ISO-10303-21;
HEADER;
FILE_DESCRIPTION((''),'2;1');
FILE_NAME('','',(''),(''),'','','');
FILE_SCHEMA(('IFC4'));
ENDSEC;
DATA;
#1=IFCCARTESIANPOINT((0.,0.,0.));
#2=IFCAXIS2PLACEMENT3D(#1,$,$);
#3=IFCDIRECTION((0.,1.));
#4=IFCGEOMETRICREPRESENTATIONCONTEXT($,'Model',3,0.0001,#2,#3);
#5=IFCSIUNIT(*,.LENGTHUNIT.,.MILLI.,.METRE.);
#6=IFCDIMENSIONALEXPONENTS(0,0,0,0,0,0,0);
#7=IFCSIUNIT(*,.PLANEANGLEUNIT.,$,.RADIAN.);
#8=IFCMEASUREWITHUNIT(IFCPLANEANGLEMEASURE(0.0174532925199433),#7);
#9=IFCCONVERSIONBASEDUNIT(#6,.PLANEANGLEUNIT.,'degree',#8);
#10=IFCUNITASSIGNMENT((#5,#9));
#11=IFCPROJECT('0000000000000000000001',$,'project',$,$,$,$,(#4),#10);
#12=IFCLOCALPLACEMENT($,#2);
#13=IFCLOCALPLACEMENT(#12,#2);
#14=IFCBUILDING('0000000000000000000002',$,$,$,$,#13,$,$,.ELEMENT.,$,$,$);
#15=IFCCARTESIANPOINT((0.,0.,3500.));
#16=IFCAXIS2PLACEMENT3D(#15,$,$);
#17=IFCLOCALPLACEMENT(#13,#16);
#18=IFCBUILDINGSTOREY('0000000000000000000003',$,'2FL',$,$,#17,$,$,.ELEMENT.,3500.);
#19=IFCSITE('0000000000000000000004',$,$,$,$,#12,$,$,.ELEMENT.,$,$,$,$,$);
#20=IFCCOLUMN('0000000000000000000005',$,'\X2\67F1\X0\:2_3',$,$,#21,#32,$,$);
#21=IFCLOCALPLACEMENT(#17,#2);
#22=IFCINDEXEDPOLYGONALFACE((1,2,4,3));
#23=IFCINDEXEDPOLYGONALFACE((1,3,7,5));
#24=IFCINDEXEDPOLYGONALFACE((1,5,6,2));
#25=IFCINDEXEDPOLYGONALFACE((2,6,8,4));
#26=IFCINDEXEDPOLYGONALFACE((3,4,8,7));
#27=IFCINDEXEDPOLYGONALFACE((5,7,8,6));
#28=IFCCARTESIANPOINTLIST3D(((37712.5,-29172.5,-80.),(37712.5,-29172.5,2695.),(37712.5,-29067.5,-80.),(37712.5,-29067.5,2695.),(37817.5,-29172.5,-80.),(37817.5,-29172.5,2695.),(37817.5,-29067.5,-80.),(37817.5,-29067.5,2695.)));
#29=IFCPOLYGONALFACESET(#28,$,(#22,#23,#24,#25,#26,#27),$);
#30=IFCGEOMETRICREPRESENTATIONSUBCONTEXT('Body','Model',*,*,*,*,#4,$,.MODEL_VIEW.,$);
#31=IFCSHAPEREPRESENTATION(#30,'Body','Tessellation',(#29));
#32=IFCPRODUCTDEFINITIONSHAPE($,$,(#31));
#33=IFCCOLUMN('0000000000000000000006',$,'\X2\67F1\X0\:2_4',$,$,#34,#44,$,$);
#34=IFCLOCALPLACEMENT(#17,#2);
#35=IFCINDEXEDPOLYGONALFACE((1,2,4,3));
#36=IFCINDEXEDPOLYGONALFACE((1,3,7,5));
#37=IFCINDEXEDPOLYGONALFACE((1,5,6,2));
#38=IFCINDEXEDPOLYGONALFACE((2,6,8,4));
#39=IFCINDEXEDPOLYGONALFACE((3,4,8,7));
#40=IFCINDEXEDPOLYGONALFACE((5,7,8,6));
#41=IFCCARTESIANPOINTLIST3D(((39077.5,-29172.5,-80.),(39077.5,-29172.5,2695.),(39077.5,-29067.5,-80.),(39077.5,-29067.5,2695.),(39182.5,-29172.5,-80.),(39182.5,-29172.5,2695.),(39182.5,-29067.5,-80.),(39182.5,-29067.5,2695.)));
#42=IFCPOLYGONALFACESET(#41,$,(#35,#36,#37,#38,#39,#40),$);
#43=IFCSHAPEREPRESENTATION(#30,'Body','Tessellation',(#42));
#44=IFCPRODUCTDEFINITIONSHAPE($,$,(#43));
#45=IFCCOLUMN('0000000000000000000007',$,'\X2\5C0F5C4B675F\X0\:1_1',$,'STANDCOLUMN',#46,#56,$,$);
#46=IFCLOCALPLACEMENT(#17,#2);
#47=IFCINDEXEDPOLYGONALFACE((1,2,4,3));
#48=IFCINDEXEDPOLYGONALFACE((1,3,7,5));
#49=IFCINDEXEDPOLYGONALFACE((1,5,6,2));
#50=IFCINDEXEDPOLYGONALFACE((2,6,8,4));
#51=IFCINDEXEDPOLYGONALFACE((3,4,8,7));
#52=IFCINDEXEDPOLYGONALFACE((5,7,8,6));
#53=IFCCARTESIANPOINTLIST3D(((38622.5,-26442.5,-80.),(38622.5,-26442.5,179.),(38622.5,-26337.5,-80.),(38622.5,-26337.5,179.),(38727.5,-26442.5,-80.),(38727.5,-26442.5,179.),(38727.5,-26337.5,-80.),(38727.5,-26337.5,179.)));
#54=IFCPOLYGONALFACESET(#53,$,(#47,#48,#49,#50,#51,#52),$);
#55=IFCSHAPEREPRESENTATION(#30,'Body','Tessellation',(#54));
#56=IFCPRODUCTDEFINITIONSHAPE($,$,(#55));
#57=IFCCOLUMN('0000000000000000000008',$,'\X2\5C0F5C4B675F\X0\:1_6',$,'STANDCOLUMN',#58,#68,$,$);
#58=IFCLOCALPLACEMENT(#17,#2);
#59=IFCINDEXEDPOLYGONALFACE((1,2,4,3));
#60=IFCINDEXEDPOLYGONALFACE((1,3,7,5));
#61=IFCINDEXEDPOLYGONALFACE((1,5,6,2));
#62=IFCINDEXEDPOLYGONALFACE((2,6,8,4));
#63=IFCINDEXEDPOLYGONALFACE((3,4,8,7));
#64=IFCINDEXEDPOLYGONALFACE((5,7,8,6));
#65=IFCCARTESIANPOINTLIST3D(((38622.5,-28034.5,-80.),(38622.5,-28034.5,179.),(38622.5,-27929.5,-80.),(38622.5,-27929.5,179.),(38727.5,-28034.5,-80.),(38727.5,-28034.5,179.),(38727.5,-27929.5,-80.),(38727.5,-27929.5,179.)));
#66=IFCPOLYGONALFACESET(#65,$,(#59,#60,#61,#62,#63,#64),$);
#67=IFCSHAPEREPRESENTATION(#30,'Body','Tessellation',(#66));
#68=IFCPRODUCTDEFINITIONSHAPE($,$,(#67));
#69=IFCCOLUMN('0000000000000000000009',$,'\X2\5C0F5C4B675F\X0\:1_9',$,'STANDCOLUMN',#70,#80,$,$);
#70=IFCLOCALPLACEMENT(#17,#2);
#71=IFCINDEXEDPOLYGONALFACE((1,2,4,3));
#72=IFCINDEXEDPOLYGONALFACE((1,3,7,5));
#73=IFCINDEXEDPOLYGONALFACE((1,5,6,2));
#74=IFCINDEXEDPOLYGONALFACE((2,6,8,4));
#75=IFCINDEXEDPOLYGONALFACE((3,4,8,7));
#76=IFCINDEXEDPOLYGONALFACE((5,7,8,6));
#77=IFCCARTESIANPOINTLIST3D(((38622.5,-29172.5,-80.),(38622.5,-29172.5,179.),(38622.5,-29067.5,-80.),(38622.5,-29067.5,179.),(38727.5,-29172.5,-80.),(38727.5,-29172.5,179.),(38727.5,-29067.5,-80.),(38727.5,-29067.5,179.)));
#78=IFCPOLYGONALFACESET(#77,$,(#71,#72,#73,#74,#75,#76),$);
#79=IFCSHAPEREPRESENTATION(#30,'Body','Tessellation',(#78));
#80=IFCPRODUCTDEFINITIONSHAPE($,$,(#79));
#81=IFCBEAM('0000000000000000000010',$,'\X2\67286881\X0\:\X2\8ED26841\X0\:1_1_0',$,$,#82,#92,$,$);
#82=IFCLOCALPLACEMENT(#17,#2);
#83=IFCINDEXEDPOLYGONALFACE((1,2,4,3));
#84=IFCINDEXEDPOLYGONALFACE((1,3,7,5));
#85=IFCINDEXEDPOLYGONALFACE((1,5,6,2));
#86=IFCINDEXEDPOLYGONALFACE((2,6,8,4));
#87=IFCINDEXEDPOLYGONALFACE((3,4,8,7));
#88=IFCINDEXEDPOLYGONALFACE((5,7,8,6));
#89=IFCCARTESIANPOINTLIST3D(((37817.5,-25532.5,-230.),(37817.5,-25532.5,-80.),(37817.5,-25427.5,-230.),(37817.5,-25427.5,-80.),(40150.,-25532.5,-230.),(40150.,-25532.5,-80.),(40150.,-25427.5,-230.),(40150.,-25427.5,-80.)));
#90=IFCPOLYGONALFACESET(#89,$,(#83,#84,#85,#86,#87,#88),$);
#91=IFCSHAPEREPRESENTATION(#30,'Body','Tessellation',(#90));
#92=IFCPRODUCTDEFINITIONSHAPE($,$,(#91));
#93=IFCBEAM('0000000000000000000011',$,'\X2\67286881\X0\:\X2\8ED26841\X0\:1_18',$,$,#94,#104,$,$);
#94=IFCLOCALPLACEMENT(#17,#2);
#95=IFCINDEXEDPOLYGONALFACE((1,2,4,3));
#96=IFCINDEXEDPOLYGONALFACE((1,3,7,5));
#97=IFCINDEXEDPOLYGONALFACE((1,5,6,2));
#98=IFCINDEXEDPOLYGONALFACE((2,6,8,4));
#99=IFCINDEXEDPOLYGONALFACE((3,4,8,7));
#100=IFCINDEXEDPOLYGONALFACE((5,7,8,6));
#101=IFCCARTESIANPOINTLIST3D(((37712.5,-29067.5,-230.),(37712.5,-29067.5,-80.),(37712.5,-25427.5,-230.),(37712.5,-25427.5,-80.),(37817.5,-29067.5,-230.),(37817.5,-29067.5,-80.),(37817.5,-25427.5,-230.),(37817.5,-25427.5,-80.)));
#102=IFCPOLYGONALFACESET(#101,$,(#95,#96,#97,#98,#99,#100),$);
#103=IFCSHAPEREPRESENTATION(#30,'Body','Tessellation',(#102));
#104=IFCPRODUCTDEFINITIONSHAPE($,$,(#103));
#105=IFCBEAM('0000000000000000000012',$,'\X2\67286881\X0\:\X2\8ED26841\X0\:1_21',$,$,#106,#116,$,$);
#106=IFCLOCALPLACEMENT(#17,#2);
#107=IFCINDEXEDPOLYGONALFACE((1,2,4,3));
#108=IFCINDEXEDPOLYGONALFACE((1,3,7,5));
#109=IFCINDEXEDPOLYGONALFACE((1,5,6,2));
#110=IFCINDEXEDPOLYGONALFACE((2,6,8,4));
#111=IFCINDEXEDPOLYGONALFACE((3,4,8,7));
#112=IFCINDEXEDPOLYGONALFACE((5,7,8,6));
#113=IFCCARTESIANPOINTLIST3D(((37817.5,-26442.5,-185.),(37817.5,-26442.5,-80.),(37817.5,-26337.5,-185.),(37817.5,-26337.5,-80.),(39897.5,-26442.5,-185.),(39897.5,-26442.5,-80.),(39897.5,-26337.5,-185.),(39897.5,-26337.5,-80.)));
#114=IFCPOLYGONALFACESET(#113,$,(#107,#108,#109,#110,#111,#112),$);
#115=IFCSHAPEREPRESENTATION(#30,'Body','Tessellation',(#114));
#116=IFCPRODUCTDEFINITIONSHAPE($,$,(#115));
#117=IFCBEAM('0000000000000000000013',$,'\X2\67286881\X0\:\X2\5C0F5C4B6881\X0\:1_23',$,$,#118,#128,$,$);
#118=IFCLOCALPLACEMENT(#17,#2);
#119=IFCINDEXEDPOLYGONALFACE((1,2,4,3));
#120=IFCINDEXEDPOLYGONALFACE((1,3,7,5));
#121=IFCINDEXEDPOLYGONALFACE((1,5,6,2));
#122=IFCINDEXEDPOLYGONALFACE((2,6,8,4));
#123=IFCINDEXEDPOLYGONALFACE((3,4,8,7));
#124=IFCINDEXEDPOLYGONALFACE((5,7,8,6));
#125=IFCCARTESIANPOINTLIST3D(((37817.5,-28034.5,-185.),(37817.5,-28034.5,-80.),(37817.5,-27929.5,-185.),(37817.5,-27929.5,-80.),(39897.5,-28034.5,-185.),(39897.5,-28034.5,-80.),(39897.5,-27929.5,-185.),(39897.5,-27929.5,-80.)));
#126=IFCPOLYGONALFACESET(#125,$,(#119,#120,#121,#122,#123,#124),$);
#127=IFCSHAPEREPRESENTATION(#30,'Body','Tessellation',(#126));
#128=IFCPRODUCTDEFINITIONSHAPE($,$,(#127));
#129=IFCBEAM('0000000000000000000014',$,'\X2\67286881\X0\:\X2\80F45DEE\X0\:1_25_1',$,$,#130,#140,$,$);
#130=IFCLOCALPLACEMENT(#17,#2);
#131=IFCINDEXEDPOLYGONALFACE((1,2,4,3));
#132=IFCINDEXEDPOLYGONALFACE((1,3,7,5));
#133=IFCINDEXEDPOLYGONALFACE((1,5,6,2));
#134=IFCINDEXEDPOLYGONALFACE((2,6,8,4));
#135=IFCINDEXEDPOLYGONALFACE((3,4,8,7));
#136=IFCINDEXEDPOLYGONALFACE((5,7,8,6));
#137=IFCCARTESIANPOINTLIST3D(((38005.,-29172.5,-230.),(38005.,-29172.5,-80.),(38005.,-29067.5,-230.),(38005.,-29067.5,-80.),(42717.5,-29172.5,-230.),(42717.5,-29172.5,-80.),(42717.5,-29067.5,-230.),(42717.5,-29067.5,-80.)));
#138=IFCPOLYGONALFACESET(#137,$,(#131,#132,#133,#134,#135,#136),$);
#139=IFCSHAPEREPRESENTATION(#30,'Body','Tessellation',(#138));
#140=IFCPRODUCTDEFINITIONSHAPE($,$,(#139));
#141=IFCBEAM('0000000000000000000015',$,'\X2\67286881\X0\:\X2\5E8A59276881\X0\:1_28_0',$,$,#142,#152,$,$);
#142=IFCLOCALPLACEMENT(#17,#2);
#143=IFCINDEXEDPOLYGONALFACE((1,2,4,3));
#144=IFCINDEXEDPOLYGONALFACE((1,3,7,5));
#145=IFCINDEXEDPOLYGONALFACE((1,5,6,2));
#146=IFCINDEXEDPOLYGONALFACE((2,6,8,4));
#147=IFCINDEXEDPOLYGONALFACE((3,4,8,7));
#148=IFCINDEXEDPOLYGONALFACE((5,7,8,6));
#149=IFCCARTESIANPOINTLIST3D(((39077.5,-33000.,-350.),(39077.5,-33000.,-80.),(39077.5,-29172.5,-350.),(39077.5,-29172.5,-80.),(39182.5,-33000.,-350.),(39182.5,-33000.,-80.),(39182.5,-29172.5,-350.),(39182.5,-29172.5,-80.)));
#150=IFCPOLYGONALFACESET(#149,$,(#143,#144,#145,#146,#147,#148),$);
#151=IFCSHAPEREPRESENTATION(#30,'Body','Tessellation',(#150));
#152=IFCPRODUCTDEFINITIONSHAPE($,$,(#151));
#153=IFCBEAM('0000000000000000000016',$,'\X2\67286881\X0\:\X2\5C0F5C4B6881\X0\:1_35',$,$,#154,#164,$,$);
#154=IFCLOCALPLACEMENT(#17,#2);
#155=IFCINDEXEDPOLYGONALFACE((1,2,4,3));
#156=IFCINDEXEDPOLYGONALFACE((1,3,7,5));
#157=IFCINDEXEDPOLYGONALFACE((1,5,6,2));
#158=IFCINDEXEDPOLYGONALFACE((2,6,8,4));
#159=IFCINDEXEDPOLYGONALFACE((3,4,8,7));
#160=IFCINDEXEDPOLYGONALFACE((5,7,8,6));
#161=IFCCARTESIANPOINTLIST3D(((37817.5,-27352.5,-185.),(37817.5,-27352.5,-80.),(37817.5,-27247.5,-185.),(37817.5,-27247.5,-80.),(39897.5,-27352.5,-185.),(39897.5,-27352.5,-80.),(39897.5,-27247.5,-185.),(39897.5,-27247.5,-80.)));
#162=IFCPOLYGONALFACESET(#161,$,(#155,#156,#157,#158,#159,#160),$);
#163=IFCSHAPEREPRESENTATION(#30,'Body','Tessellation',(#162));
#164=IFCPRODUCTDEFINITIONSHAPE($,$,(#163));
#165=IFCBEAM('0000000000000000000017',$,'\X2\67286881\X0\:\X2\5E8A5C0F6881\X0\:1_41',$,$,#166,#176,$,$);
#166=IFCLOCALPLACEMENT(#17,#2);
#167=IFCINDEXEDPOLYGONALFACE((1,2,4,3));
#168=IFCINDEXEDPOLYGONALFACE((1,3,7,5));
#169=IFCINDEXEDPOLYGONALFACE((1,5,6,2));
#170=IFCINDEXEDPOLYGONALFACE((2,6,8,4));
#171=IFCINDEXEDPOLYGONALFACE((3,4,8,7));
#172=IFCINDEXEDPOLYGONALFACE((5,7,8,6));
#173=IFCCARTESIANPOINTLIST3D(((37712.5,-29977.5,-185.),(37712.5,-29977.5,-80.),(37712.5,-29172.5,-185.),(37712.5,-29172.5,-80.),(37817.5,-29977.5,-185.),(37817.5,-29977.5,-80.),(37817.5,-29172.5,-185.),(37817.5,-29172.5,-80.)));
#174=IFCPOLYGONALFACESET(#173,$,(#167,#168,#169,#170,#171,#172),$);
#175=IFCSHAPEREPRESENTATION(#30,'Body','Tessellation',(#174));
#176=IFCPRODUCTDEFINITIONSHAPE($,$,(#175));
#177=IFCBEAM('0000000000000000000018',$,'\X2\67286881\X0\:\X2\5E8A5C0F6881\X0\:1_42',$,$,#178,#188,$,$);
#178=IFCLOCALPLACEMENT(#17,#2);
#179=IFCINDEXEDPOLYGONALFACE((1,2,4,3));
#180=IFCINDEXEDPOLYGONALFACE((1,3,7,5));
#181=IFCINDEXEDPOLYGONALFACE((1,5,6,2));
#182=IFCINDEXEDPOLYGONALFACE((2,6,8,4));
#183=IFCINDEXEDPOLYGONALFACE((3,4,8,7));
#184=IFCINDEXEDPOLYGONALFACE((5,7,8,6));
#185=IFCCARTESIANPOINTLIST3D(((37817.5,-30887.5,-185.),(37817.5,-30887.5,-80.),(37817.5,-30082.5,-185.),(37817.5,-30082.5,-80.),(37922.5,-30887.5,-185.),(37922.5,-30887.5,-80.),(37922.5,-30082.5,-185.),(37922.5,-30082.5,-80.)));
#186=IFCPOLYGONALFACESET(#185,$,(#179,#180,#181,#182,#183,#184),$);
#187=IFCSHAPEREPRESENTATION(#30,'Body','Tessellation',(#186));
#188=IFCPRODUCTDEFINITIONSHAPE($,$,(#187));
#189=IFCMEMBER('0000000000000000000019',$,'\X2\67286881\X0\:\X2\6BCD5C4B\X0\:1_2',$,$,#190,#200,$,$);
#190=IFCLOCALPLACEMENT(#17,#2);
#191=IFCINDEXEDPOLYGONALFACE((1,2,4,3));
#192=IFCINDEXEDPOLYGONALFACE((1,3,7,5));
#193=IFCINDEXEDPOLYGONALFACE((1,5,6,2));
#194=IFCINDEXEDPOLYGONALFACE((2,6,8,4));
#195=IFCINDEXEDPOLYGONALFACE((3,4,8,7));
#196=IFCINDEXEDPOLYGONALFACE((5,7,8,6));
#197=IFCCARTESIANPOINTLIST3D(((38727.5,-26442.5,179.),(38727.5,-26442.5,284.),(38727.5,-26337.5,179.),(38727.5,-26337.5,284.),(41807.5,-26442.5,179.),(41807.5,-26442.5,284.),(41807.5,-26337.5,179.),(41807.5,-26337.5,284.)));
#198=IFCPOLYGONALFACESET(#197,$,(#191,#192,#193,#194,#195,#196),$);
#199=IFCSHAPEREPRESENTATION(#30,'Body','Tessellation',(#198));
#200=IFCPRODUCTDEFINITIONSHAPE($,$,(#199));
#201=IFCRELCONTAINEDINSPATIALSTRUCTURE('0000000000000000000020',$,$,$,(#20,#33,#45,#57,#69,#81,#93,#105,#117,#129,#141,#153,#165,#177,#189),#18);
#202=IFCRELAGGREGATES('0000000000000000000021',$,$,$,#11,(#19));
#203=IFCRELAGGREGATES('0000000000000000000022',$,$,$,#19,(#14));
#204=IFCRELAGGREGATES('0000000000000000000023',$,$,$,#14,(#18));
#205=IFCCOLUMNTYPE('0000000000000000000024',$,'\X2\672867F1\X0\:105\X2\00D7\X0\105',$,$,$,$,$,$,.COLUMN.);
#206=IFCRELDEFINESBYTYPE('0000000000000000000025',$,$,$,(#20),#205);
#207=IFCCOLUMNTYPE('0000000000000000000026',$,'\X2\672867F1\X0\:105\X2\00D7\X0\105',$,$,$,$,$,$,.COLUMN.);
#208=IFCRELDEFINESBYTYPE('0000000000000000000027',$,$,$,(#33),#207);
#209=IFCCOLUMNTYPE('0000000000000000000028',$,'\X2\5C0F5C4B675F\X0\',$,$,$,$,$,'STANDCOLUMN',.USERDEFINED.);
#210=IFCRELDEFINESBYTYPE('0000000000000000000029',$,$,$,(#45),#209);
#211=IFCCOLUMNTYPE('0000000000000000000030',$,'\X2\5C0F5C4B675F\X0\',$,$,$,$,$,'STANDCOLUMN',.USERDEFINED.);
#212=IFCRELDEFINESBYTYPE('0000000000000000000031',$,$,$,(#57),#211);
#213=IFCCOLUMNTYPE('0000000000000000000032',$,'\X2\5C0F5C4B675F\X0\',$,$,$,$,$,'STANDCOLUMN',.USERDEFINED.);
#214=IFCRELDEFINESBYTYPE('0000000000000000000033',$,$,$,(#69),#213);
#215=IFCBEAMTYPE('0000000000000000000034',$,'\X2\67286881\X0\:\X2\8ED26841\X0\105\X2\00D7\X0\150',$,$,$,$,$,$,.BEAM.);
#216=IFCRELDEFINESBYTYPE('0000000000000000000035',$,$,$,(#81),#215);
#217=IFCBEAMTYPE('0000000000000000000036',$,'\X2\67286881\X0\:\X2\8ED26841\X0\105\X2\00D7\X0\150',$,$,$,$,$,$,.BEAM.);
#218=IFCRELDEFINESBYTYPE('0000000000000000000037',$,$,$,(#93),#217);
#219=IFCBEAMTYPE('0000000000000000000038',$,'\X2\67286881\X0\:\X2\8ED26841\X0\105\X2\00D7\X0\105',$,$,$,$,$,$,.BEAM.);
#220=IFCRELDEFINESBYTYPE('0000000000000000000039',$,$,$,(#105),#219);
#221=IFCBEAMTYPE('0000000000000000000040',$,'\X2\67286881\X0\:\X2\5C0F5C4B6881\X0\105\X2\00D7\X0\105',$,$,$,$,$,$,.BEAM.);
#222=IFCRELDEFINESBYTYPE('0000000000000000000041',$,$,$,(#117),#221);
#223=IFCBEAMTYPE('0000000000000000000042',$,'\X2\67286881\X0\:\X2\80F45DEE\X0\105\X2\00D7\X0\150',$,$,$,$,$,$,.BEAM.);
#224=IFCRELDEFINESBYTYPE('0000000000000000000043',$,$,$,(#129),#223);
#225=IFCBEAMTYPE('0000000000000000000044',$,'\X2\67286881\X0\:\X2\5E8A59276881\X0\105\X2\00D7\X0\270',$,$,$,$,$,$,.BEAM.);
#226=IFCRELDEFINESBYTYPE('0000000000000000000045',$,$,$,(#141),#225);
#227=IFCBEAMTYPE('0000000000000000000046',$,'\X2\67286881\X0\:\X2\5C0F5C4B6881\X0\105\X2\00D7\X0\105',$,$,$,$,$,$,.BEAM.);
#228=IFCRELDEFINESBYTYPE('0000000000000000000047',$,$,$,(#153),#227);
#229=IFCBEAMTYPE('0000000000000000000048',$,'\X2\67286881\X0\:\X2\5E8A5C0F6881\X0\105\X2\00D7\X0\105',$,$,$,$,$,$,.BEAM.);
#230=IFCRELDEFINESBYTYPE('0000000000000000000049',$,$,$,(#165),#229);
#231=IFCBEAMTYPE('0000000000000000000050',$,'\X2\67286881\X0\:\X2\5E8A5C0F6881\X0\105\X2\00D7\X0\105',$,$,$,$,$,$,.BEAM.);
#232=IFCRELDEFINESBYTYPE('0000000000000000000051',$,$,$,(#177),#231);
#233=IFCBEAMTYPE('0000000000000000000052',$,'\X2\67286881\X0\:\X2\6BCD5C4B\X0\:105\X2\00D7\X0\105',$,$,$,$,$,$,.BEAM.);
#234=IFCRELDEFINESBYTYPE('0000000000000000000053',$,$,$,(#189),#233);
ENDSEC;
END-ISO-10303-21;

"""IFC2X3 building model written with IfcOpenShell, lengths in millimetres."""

from ifc_helpers import new_model, entity, si_unit, converted_unit, direction, frame, origin, origin_with_axes, origin_2d, place, context, subcontext, project, spatial, rectangle, extrude, type_object, element, save


model = new_model("IFC2X3")

# Units and contexts
model_context = context("Model", 3, precision=0.0001, world=origin(), true_north=direction((0.0, 1.0)))
body_context = subcontext(model_context, "Body", "Model", "MODEL_VIEW")
ifc_project = project(units=[si_unit("LENGTHUNIT", "METRE", prefix="MILLI"), converted_unit("PLANEANGLEUNIT", "degree", entity("IfcPlaneAngleMeasure", 0.0174532925199433), si_unit("PLANEANGLEUNIT", "RADIAN"), dimensions=[0, 0, 0, 0, 0, 0, 0])], contexts=[model_context])

# Site, building, storey
site_placement = place(None, origin())
site = spatial("IfcSite", under=ifc_project, at=site_placement, CompositionType="ELEMENT")
building_placement = place(site_placement, origin())
building = spatial("IfcBuilding", under=site, at=building_placement, CompositionType="ELEMENT")
storey_placement = place(building_placement, frame((0.0, 0.0, 3500.0)))
storey = spatial("IfcBuildingStorey", under=building, at=storey_placement, Name="2FL", CompositionType="ELEMENT", Elevation=3500.0)

# Columns
column_type_1 = type_object("IfcColumnType", Name="木柱:105×105", PredefinedType="COLUMN")
column_1_placement = place(storey_placement, frame((37765.0, -29120.0, -80.0)))
element("IfcColumn", 1, at=column_1_placement, inside=storey, type_object=column_type_1, Name="柱:2_3", context=body_context, shape_type="SweptSolid", body=[
    extrude(rectangle(XDim=105.0, YDim=105.0, at=origin_2d()), origin_with_axes(), (0.0, 0.0, 1.0), 2775.0),
])
column_type_2 = type_object("IfcColumnType", Name="木柱:105×105", PredefinedType="COLUMN")
column_2_placement = place(storey_placement, frame((39130.0, -29120.0, -80.0)))
element("IfcColumn", 2, at=column_2_placement, inside=storey, type_object=column_type_2, Name="柱:2_4", context=body_context, shape_type="SweptSolid", body=[
    extrude(rectangle(XDim=105.0, YDim=105.0, at=origin_2d()), origin_with_axes(), (0.0, 0.0, 1.0), 2775.0),
])
column_type_3 = type_object("IfcColumnType", Name="小屋束", ElementType="STANDCOLUMN", PredefinedType="USERDEFINED")
column_3_placement = place(storey_placement, frame((38675.0, -26390.0, -80.0)))
element("IfcColumn", 3, at=column_3_placement, inside=storey, type_object=column_type_3, Name="小屋束:1_1", ObjectType="STANDCOLUMN", context=body_context, shape_type="SweptSolid", body=[
    extrude(rectangle(XDim=105.0, YDim=105.0, at=origin_2d()), origin_with_axes(), (0.0, 0.0, 1.0), 259.0),
])
column_type_4 = type_object("IfcColumnType", Name="小屋束", ElementType="STANDCOLUMN", PredefinedType="USERDEFINED")
column_4_placement = place(storey_placement, frame((38675.0, -27982.0, -80.0)))
element("IfcColumn", 4, at=column_4_placement, inside=storey, type_object=column_type_4, Name="小屋束:1_6", ObjectType="STANDCOLUMN", context=body_context, shape_type="SweptSolid", body=[
    extrude(rectangle(XDim=105.0, YDim=105.0, at=origin_2d()), origin_with_axes(), (0.0, 0.0, 1.0), 259.0),
])
column_type_5 = type_object("IfcColumnType", Name="小屋束", ElementType="STANDCOLUMN", PredefinedType="USERDEFINED")
column_5_placement = place(storey_placement, frame((38675.0, -29120.0, -80.0)))
element("IfcColumn", 5, at=column_5_placement, inside=storey, type_object=column_type_5, Name="小屋束:1_9", ObjectType="STANDCOLUMN", context=body_context, shape_type="SweptSolid", body=[
    extrude(rectangle(XDim=105.0, YDim=105.0, at=origin_2d()), origin_with_axes(), (0.0, 0.0, 1.0), 259.0),
])

# Beams
beam_type_1 = type_object("IfcBeamType", Name="木梁:軒桁105×150", PredefinedType="BEAM")
beam_1_placement = place(storey_placement, frame((37817.5, -25480.0, -155.0), z_axis=(1.0, 0.0, 0.0), x_axis=(0.0, 1.0, 0.0)))
element("IfcBeam", 6, at=beam_1_placement, inside=storey, type_object=beam_type_1, Name="木梁:軒桁:1_1_0", context=body_context, shape_type="SweptSolid", body=[
    extrude(rectangle(XDim=105.0, YDim=150.0, at=origin_2d()), origin_with_axes(), (0.0, 0.0, 1.0), 2332.5),
])
beam_type_2 = type_object("IfcBeamType", Name="木梁:軒桁105×150", PredefinedType="BEAM")
beam_2_placement = place(storey_placement, frame((37765.0, -25427.5, -155.0), z_axis=(0.0, -1.0, 0.0), x_axis=(1.0, 0.0, 0.0)))
element("IfcBeam", 7, at=beam_2_placement, inside=storey, type_object=beam_type_2, Name="木梁:軒桁:1_18", context=body_context, shape_type="SweptSolid", body=[
    extrude(rectangle(XDim=105.0, YDim=150.0, at=origin_2d()), origin_with_axes(), (0.0, 0.0, 1.0), 3640.0),
])
beam_type_3 = type_object("IfcBeamType", Name="木梁:軒桁105×105", PredefinedType="BEAM")
beam_3_placement = place(storey_placement, frame((37817.5, -26390.0, -132.5), z_axis=(1.0, 0.0, 0.0), x_axis=(0.0, 1.0, 0.0)))
element("IfcBeam", 8, at=beam_3_placement, inside=storey, type_object=beam_type_3, Name="木梁:軒桁:1_21", context=body_context, shape_type="SweptSolid", body=[
    extrude(rectangle(XDim=105.0, YDim=105.0, at=origin_2d()), origin_with_axes(), (0.0, 0.0, 1.0), 2080.0),
])
beam_type_4 = type_object("IfcBeamType", Name="木梁:小屋梁105×105", PredefinedType="BEAM")
beam_4_placement = place(storey_placement, frame((37817.5, -27982.0, -132.5), z_axis=(1.0, 0.0, 0.0), x_axis=(0.0, 1.0, 0.0)))
element("IfcBeam", 9, at=beam_4_placement, inside=storey, type_object=beam_type_4, Name="木梁:小屋梁:1_23", context=body_context, shape_type="SweptSolid", body=[
    extrude(rectangle(XDim=105.0, YDim=105.0, at=origin_2d()), origin_with_axes(), (0.0, 0.0, 1.0), 2080.0),
])
beam_type_5 = type_object("IfcBeamType", Name="木梁:胴差105×150", PredefinedType="BEAM")
beam_5_placement = place(storey_placement, frame((38005.0, -29120.0, -155.0), z_axis=(1.0, 0.0, 0.0), x_axis=(0.0, 1.0, 0.0)))
element("IfcBeam", 10, at=beam_5_placement, inside=storey, type_object=beam_type_5, Name="木梁:胴差:1_25_1", context=body_context, shape_type="SweptSolid", body=[
    extrude(rectangle(XDim=105.0, YDim=150.0, at=origin_2d()), origin_with_axes(), (0.0, 0.0, 1.0), 4712.5),
])
beam_type_6 = type_object("IfcBeamType", Name="木梁:床大梁105×270", PredefinedType="BEAM")
beam_6_placement = place(storey_placement, frame((39130.0, -29172.5, -215.0), z_axis=(0.0, -1.0, 0.0), x_axis=(1.0, 0.0, 0.0)))
element("IfcBeam", 11, at=beam_6_placement, inside=storey, type_object=beam_type_6, Name="木梁:床大梁:1_28_0", context=body_context, shape_type="SweptSolid", body=[
    extrude(rectangle(XDim=105.0, YDim=270.0, at=origin_2d()), origin_with_axes(), (0.0, 0.0, 1.0), 3827.5),
])
beam_type_7 = type_object("IfcBeamType", Name="木梁:小屋梁105×105", PredefinedType="BEAM")
beam_7_placement = place(storey_placement, frame((37817.5, -27300.0, -132.5), z_axis=(1.0, 0.0, 0.0), x_axis=(0.0, 1.0, 0.0)))
element("IfcBeam", 12, at=beam_7_placement, inside=storey, type_object=beam_type_7, Name="木梁:小屋梁:1_35", context=body_context, shape_type="SweptSolid", body=[
    extrude(rectangle(XDim=105.0, YDim=105.0, at=origin_2d()), origin_with_axes(), (0.0, 0.0, 1.0), 2080.0),
])
beam_type_8 = type_object("IfcBeamType", Name="木梁:床小梁105×105", PredefinedType="BEAM")
beam_8_placement = place(storey_placement, frame((37765.0, -29172.5, -132.5), z_axis=(0.0, -1.0, 0.0), x_axis=(1.0, 0.0, 0.0)))
element("IfcBeam", 13, at=beam_8_placement, inside=storey, type_object=beam_type_8, Name="木梁:床小梁:1_41", context=body_context, shape_type="SweptSolid", body=[
    extrude(rectangle(XDim=105.0, YDim=105.0, at=origin_2d()), origin_with_axes(), (0.0, 0.0, 1.0), 805.0),
])
beam_type_9 = type_object("IfcBeamType", Name="木梁:床小梁105×105", PredefinedType="BEAM")
beam_9_placement = place(storey_placement, frame((37870.0, -30082.5, -132.5), z_axis=(0.0, -1.0, 0.0), x_axis=(1.0, 0.0, 0.0)))
element("IfcBeam", 14, at=beam_9_placement, inside=storey, type_object=beam_type_9, Name="木梁:床小梁:1_42", context=body_context, shape_type="SweptSolid", body=[
    extrude(rectangle(XDim=105.0, YDim=105.0, at=origin_2d()), origin_with_axes(), (0.0, 0.0, 1.0), 805.0),
])

# Member
beam_type_10 = type_object("IfcBeamType", Name="木梁:母屋:105×105", PredefinedType="BEAM")
member_1_placement = place(storey_placement, frame((38727.5, -26390.0, 231.5), z_axis=(1.0, 0.0, 0.0), x_axis=(0.0, -1.0, 0.0)))
element("IfcMember", 15, at=member_1_placement, inside=storey, type_object=beam_type_10, Name="木梁:母屋:1_2", context=body_context, shape_type="SweptSolid", body=[
    extrude(rectangle(XDim=105.0, YDim=105.0, at=origin_2d()), origin_with_axes(), (0.0, 0.0, 1.0), 3080.0),
])

save(model, "model.ifc")
